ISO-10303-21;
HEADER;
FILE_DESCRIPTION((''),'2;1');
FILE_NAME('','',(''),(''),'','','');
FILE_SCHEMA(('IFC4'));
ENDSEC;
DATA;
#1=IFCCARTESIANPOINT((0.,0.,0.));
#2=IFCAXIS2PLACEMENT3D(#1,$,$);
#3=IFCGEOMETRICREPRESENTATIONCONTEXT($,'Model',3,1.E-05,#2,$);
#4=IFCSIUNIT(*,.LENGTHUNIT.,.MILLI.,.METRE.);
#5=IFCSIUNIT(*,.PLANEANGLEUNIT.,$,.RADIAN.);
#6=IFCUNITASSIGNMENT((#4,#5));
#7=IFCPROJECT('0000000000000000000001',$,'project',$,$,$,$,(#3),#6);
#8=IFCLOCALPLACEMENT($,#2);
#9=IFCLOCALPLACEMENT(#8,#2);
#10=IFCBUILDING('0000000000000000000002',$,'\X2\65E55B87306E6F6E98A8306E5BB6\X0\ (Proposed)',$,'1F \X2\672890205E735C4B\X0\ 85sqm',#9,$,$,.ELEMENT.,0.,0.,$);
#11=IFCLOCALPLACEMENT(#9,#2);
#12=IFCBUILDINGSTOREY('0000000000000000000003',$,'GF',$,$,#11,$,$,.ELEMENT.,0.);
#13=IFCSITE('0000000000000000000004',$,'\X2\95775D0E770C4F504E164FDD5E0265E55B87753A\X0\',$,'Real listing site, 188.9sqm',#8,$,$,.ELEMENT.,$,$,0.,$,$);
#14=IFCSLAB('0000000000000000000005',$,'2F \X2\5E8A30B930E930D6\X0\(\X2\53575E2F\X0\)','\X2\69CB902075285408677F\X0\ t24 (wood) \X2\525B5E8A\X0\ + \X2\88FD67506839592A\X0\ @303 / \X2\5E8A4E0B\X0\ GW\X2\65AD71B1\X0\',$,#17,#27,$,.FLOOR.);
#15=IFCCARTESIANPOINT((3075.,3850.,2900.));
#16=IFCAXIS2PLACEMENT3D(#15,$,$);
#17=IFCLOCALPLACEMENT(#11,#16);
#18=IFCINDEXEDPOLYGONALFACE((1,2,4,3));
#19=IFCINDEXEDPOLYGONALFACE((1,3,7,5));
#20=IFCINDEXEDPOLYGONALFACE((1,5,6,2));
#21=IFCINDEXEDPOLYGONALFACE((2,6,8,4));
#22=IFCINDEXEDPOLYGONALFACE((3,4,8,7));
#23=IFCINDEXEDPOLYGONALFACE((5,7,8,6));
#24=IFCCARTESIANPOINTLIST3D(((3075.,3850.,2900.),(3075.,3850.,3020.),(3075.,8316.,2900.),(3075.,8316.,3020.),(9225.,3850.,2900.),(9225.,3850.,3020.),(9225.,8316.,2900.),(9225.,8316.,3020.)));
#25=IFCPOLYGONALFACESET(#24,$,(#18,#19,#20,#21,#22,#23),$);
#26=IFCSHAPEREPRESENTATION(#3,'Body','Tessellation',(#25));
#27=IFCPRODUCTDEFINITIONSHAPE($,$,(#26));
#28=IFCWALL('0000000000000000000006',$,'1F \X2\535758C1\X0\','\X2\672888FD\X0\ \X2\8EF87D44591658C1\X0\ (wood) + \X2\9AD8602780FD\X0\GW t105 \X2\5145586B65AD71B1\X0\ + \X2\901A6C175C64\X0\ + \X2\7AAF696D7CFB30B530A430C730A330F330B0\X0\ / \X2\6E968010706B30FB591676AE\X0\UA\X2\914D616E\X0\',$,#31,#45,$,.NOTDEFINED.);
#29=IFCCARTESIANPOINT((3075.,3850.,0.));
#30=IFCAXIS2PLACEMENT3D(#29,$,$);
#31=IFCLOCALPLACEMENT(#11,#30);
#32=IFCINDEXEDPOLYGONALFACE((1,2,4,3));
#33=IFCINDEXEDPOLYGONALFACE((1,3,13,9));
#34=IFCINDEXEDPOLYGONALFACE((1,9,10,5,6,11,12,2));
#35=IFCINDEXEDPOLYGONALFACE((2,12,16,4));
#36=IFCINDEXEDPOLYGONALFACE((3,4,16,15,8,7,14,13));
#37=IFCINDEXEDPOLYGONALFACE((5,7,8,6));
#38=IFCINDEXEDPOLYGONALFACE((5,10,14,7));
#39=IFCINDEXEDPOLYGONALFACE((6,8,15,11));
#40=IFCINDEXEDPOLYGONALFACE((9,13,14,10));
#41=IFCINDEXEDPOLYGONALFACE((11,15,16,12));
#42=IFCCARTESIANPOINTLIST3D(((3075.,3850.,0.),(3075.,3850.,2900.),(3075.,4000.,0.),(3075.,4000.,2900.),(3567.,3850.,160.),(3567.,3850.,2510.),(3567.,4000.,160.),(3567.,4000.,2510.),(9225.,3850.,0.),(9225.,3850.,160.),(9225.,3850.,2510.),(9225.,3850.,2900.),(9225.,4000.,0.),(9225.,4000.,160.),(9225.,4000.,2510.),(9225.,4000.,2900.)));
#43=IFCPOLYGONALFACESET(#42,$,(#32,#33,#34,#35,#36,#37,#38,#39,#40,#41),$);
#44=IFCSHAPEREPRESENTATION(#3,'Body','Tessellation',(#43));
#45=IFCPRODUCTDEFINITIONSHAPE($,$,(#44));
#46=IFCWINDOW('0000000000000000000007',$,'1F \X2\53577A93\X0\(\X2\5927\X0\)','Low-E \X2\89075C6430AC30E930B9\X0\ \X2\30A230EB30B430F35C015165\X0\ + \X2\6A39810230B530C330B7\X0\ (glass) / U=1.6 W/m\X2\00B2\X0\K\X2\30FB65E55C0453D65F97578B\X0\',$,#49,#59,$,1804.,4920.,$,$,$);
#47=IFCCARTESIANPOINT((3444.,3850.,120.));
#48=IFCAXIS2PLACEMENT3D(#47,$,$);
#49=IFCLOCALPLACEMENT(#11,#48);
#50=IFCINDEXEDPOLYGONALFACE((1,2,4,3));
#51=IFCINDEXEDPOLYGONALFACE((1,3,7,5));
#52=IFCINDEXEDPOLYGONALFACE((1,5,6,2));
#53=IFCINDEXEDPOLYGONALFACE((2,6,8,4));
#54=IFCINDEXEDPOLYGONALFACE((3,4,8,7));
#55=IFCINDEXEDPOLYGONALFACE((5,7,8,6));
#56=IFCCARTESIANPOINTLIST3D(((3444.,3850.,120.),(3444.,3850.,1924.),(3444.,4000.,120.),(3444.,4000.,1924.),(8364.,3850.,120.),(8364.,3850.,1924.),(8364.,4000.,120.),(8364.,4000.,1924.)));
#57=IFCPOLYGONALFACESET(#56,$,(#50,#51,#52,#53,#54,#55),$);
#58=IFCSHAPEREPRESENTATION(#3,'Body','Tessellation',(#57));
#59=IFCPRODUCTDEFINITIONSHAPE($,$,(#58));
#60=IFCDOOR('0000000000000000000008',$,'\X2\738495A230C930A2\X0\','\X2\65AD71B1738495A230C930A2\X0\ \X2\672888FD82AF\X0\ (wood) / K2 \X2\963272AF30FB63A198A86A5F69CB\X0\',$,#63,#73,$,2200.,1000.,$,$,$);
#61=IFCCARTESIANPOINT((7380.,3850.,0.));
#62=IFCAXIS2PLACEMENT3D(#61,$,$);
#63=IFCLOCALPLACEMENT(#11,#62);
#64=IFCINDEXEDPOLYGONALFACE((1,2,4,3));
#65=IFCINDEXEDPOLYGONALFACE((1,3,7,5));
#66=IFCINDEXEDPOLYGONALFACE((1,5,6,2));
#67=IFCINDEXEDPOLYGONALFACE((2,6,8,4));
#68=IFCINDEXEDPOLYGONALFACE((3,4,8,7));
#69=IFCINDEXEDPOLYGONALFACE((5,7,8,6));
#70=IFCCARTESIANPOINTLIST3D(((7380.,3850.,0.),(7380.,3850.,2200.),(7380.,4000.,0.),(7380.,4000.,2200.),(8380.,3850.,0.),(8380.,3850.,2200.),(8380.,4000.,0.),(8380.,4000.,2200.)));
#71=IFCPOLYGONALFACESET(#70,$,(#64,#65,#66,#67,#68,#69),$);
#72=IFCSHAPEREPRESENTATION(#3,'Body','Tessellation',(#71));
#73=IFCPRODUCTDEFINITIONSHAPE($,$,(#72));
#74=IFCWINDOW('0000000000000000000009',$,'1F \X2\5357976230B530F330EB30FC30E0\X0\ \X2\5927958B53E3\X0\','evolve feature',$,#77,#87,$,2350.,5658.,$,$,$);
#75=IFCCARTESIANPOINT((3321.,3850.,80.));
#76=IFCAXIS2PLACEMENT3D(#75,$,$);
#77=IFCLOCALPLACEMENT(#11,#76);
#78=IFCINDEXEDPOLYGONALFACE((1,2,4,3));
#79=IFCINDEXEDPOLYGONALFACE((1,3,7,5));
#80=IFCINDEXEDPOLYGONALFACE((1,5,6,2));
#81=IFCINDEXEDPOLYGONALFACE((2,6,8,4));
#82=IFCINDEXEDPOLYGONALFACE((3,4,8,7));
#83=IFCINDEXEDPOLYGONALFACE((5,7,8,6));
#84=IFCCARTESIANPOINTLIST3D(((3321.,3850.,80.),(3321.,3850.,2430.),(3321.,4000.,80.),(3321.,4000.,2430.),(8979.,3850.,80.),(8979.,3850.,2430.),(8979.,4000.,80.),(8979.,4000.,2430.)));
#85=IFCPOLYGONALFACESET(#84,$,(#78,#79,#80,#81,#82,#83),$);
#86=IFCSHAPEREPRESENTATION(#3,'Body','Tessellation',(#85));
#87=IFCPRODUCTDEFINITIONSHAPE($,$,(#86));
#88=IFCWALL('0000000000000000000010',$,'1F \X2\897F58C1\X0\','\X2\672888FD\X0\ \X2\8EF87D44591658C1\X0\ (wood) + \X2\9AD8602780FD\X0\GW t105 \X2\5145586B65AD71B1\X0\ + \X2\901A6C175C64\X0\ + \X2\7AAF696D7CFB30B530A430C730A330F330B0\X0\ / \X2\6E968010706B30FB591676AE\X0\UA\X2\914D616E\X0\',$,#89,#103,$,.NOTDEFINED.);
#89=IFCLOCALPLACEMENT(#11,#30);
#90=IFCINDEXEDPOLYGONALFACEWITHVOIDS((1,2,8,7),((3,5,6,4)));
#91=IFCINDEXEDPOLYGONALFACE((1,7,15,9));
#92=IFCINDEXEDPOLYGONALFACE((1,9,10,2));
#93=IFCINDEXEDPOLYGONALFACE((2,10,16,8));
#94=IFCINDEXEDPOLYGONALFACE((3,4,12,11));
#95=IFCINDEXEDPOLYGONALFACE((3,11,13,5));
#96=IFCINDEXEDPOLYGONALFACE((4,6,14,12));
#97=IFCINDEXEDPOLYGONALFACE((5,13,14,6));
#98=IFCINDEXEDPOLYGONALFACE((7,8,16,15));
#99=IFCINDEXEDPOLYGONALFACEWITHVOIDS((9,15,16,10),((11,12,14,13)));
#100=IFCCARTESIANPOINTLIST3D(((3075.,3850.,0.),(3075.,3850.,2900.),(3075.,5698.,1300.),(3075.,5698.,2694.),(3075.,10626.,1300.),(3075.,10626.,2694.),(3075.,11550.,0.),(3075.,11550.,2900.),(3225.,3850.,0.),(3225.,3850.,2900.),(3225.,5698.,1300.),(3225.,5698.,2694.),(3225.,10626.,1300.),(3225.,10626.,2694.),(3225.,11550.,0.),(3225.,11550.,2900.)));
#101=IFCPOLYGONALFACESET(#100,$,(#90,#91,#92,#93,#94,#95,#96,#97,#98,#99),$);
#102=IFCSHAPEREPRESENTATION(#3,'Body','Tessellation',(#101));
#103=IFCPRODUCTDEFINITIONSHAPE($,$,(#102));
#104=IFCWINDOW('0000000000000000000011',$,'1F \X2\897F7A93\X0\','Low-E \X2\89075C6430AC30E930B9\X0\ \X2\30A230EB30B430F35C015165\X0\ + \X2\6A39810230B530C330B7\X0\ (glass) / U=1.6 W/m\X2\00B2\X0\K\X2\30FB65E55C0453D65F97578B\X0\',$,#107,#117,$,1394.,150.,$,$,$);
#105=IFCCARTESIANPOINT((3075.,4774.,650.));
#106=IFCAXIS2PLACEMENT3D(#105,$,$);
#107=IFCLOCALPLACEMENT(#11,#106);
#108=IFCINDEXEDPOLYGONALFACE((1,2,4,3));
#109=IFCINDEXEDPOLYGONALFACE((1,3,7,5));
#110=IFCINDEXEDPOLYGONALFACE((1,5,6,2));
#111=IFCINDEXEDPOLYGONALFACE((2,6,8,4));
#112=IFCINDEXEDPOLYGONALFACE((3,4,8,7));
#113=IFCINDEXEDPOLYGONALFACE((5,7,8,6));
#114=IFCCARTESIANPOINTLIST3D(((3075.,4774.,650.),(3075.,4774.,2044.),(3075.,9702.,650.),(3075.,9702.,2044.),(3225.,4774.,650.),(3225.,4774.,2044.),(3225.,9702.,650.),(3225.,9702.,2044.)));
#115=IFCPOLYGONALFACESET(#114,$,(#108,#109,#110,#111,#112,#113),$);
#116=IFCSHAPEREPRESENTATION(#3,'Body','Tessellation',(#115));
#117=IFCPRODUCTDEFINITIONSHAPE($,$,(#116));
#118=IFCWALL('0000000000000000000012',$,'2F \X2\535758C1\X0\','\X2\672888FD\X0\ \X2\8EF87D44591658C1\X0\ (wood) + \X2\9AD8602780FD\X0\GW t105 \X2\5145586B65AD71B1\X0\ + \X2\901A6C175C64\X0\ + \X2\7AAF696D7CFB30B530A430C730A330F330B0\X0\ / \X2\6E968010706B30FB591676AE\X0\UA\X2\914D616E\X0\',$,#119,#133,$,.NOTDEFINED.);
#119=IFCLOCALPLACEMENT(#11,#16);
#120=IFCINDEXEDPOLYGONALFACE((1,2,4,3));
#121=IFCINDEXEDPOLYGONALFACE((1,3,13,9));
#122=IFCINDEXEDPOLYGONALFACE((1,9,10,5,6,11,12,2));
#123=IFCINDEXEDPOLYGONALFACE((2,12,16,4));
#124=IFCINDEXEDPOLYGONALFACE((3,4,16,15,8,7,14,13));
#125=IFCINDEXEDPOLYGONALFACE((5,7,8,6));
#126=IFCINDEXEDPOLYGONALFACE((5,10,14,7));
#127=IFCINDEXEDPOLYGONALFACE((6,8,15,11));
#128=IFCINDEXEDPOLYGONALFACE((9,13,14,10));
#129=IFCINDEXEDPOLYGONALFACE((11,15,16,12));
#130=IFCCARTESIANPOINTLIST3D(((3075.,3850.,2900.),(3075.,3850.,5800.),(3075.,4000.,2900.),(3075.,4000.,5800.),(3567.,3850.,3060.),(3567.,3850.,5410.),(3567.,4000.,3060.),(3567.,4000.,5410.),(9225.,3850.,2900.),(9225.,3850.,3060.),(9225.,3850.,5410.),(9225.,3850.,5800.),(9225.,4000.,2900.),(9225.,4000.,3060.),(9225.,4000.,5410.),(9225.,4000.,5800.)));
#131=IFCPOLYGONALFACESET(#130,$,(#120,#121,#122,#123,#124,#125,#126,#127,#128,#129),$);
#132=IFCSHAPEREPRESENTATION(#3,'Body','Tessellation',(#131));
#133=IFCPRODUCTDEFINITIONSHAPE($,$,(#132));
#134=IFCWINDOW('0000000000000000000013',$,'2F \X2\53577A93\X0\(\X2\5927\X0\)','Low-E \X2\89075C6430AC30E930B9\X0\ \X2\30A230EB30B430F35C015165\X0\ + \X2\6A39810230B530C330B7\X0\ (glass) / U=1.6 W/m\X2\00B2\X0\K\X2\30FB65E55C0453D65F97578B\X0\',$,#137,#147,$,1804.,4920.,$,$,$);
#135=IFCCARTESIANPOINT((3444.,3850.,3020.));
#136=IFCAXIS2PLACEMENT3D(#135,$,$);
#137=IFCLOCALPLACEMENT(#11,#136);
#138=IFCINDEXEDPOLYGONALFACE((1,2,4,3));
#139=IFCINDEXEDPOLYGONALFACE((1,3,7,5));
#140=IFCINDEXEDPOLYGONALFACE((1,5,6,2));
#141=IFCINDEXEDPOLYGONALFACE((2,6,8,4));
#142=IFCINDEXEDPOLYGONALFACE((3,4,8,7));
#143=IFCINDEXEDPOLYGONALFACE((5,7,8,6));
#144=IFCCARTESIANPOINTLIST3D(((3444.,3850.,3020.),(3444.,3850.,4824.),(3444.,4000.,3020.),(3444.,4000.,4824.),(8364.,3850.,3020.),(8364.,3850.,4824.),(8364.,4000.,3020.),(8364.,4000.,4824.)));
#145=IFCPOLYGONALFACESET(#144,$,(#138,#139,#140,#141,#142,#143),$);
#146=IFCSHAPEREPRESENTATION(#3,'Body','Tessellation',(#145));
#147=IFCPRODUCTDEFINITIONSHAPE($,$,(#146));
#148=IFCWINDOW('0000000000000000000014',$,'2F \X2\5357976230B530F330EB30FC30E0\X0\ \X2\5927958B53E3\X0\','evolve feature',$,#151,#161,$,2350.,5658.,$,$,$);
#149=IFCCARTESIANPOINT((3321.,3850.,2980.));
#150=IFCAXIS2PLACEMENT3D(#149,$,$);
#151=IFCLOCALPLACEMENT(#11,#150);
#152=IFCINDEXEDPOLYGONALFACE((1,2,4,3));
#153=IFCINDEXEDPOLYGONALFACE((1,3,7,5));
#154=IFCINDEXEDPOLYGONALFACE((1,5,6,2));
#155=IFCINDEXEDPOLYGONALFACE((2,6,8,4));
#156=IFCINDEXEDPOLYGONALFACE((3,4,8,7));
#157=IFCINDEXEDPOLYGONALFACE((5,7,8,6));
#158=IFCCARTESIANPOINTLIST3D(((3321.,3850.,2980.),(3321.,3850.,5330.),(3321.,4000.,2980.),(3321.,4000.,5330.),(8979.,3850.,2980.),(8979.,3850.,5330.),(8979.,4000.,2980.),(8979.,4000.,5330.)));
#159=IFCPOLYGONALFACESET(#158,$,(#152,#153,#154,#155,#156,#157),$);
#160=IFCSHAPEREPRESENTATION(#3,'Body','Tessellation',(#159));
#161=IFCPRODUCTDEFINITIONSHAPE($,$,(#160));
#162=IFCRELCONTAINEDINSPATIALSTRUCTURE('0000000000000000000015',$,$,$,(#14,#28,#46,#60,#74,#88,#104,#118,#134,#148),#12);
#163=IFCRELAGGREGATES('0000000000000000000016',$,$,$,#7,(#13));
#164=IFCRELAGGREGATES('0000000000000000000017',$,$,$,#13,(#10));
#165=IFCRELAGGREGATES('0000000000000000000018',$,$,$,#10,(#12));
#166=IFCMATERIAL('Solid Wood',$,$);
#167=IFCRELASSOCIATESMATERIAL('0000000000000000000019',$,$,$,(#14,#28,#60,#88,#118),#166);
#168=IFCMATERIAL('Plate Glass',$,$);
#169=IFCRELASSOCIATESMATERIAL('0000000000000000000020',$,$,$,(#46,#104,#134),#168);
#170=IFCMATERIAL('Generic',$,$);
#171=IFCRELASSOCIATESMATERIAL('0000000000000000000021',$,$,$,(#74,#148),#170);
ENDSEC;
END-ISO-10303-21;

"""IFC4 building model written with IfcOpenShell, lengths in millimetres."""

from ifc_helpers import new_model, si_unit, frame, frame_2d, origin, place, context, project, spatial, rectangle, extrude, material, element, fill, save


model = new_model("IFC4")

# Units and contexts
model_context = context("Model", 3, precision=1e-05, world=origin())
ifc_project = project(units=[si_unit("LENGTHUNIT", "METRE", prefix="MILLI"), si_unit("PLANEANGLEUNIT", "RADIAN")], contexts=[model_context])

# Site, building, storey
site_placement = place(None, origin())
site = spatial("IfcSite", under=ifc_project, at=site_placement, Name="長崎県佐世保市日宇町", ObjectType="Real listing site, 188.9sqm", CompositionType="ELEMENT", RefElevation=0.0)
building_placement = place(site_placement, origin())
building = spatial("IfcBuilding", under=site, at=building_placement, Name="日宇の潮風の家 (Proposed)", ObjectType="1F 木造平屋 85sqm", CompositionType="ELEMENT", ElevationOfRefHeight=0.0, ElevationOfTerrain=0.0)
storey_placement = place(building_placement, origin())
storey = spatial("IfcBuildingStorey", under=building, at=storey_placement, Name="GF", CompositionType="ELEMENT", Elevation=0.0)

# Slab
ifc_material_1 = material(Name="Solid Wood")
slab_1_placement = place(storey_placement, frame((3075.0, 3850.0, 2900.0)))
element("IfcSlab", 1, at=slab_1_placement, inside=storey, material=ifc_material_1, Name="2F 床スラブ(南帯)", Description="構造用合板 t24 (wood) 剛床 + 製材根太 @303 / 床下 GW断熱", PredefinedType="FLOOR", context=model_context, shape_type="SweptSolid", body=[
    extrude(rectangle(XDim=6150.0, YDim=4466.0, at=frame_2d((3075.0, 2233.0))), frame((3075.0, 3850.0, 2900.0)), (0.0, 0.0, 1.0), 120.0),
])
ifc_material_2 = material(Name="Generic")

# Wall, openings, windows, door
wall_1_placement = place(storey_placement, frame((3075.0, 3850.0, 0.0)))
wall_1 = element("IfcWall", 2, at=wall_1_placement, inside=storey, material=ifc_material_1, Name="1F 南壁", Description="木製 軸組外壁 (wood) + 高性能GW t105 充填断熱 + 通気層 + 窯業系サイディング / 準耐火・外皮UA配慮", PredefinedType="NOTDEFINED", context=model_context, shape_type="SweptSolid", body=[
    extrude(rectangle(XDim=6150.0, YDim=150.0, at=frame_2d((3075.0, 75.0))), frame((3075.0, 3850.0, 0.0)), (0.0, 0.0, 1.0), 2900.0),
])
opening_1_placement = place(storey_placement, frame((3444.0, 3850.0, 120.0)))
opening_1 = element("IfcOpeningElement", 3, at=opening_1_placement, cuts=wall_1, PredefinedType="NOTDEFINED", context=model_context, shape_type="SweptSolid", body=[
    extrude(rectangle(XDim=4920.0, YDim=150.0, at=frame_2d((2460.0, 75.0))), frame((3444.0, 3850.0, 120.0)), (0.0, 0.0, 1.0), 1804.0),
])
opening_2_placement = place(storey_placement, frame((7380.0, 3850.0, 0.0)))
opening_2 = element("IfcOpeningElement", 4, at=opening_2_placement, cuts=wall_1, PredefinedType="NOTDEFINED", context=model_context, shape_type="SweptSolid", body=[
    extrude(rectangle(XDim=1000.0, YDim=150.0, at=frame_2d((500.0, 75.0))), frame((7380.0, 3850.0, 0.0)), (0.0, 0.0, 1.0), 2200.0),
])
opening_3_placement = place(storey_placement, frame((3321.0, 3850.0, 80.0)))
opening_3 = element("IfcOpeningElement", 5, at=opening_3_placement, cuts=wall_1, PredefinedType="NOTDEFINED", context=model_context, shape_type="SweptSolid", body=[
    extrude(rectangle(XDim=5658.0, YDim=150.0, at=frame_2d((2829.0, 75.0))), frame((3321.0, 3850.0, 80.0)), (0.0, 0.0, 1.0), 2350.0),
])
ifc_material_3 = material(Name="Plate Glass")
window_1_placement = place(storey_placement, frame((3444.0, 3850.0, 120.0)))
window_1 = element("IfcWindow", 6, at=window_1_placement, inside=storey, material=ifc_material_3, Name="1F 南窓(大)", Description="Low-E 複層ガラス アルゴン封入 + 樹脂サッシ (glass) / U=1.6 W/m²K・日射取得型", OverallHeight=1804.0, OverallWidth=4920.0, context=model_context, shape_type="SweptSolid", body=[
    extrude(rectangle(XDim=4920.0, YDim=150.0, at=frame_2d((2460.0, 75.0))), frame((3444.0, 3850.0, 120.0)), (0.0, 0.0, 1.0), 1804.0),
])
fill(opening_1, window_1)
door_placement = place(storey_placement, frame((7380.0, 3850.0, 0.0)))
door = element("IfcDoor", 7, at=door_placement, inside=storey, material=ifc_material_1, Name="玄関ドア", Description="断熱玄関ドア 木製芯 (wood) / K2 防犯・採風機構", OverallHeight=2200.0, OverallWidth=1000.0, context=model_context, shape_type="SweptSolid", body=[
    extrude(rectangle(XDim=1000.0, YDim=150.0, at=frame_2d((500.0, 75.0))), frame((7380.0, 3850.0, 0.0)), (0.0, 0.0, 1.0), 2200.0),
])
fill(opening_2, door)
window_2_placement = place(storey_placement, frame((3321.0, 3850.0, 80.0)))
window_2 = element("IfcWindow", 8, at=window_2_placement, inside=storey, material=ifc_material_2, Name="1F 南面サンルーム 大開口", Description="evolve feature", OverallHeight=2350.0, OverallWidth=5658.0, context=model_context, shape_type="SweptSolid", body=[
    extrude(rectangle(XDim=5658.0, YDim=150.0, at=frame_2d((2829.0, 75.0))), frame((3321.0, 3850.0, 80.0)), (0.0, 0.0, 1.0), 2350.0),
])
fill(opening_3, window_2)

# Wall, opening, window
wall_2_placement = place(storey_placement, frame((3075.0, 3850.0, 0.0)))
wall_2 = element("IfcWall", 9, at=wall_2_placement, inside=storey, material=ifc_material_1, Name="1F 西壁", Description="木製 軸組外壁 (wood) + 高性能GW t105 充填断熱 + 通気層 + 窯業系サイディング / 準耐火・外皮UA配慮", PredefinedType="NOTDEFINED", context=model_context, shape_type="SweptSolid", body=[
    extrude(rectangle(XDim=150.0, YDim=7700.0, at=frame_2d((75.0, 3850.0))), frame((3075.0, 3850.0, 0.0)), (0.0, 0.0, 1.0), 2900.0),
])
opening_4_placement = place(storey_placement, frame((3075.0, 4774.0, 650.0)))
opening_4 = element("IfcOpeningElement", 10, at=opening_4_placement, cuts=wall_2, PredefinedType="NOTDEFINED", context=model_context, shape_type="SweptSolid", body=[
    extrude(rectangle(XDim=150.0, YDim=4928.0, at=frame_2d((75.0, 2464.0))), frame((3075.0, 4774.0, 650.0)), (0.0, 0.0, 1.0), 1394.0),
])
window_3_placement = place(storey_placement, frame((3075.0, 4774.0, 650.0)))
window_3 = element("IfcWindow", 11, at=window_3_placement, inside=storey, material=ifc_material_3, Name="1F 西窓", Description="Low-E 複層ガラス アルゴン封入 + 樹脂サッシ (glass) / U=1.6 W/m²K・日射取得型", OverallHeight=1394.0, OverallWidth=150.0, context=model_context, shape_type="SweptSolid", body=[
    extrude(rectangle(XDim=150.0, YDim=4928.0, at=frame_2d((75.0, 2464.0))), frame((3075.0, 4774.0, 650.0)), (0.0, 0.0, 1.0), 1394.0),
])
fill(opening_4, window_3)

# Wall, openings, windows
wall_3_placement = place(storey_placement, frame((3075.0, 3850.0, 2900.0)))
wall_3 = element("IfcWall", 12, at=wall_3_placement, inside=storey, material=ifc_material_1, Name="2F 南壁", Description="木製 軸組外壁 (wood) + 高性能GW t105 充填断熱 + 通気層 + 窯業系サイディング / 準耐火・外皮UA配慮", PredefinedType="NOTDEFINED", context=model_context, shape_type="SweptSolid", body=[
    extrude(rectangle(XDim=6150.0, YDim=150.0, at=frame_2d((3075.0, 75.0))), frame((3075.0, 3850.0, 2900.0)), (0.0, 0.0, 1.0), 2900.0),
])
opening_5_placement = place(storey_placement, frame((3444.0, 3850.0, 3020.0)))
opening_5 = element("IfcOpeningElement", 13, at=opening_5_placement, cuts=wall_3, PredefinedType="NOTDEFINED", context=model_context, shape_type="SweptSolid", body=[
    extrude(rectangle(XDim=4920.0, YDim=150.0, at=frame_2d((2460.0, 75.0))), frame((3444.0, 3850.0, 3020.0)), (0.0, 0.0, 1.0), 1804.0),
])
opening_6_placement = place(storey_placement, frame((3321.0, 3850.0, 2980.0)))
opening_6 = element("IfcOpeningElement", 14, at=opening_6_placement, cuts=wall_3, PredefinedType="NOTDEFINED", context=model_context, shape_type="SweptSolid", body=[
    extrude(rectangle(XDim=5658.0, YDim=150.0, at=frame_2d((2829.0, 75.0))), frame((3321.0, 3850.0, 2980.0)), (0.0, 0.0, 1.0), 2350.0),
])
window_4_placement = place(storey_placement, frame((3444.0, 3850.0, 3020.0)))
window_4 = element("IfcWindow", 15, at=window_4_placement, inside=storey, material=ifc_material_3, Name="2F 南窓(大)", Description="Low-E 複層ガラス アルゴン封入 + 樹脂サッシ (glass) / U=1.6 W/m²K・日射取得型", OverallHeight=1804.0, OverallWidth=4920.0, context=model_context, shape_type="SweptSolid", body=[
    extrude(rectangle(XDim=4920.0, YDim=150.0, at=frame_2d((2460.0, 75.0))), frame((3444.0, 3850.0, 3020.0)), (0.0, 0.0, 1.0), 1804.0),
])
fill(opening_5, window_4)
window_5_placement = place(storey_placement, frame((3321.0, 3850.0, 2980.0)))
window_5 = element("IfcWindow", 16, at=window_5_placement, inside=storey, material=ifc_material_2, Name="2F 南面サンルーム 大開口", Description="evolve feature", OverallHeight=2350.0, OverallWidth=5658.0, context=model_context, shape_type="SweptSolid", body=[
    extrude(rectangle(XDim=5658.0, YDim=150.0, at=frame_2d((2829.0, 75.0))), frame((3321.0, 3850.0, 2980.0)), (0.0, 0.0, 1.0), 2350.0),
])
fill(opening_6, window_5)

save(model, "model.ifc")
